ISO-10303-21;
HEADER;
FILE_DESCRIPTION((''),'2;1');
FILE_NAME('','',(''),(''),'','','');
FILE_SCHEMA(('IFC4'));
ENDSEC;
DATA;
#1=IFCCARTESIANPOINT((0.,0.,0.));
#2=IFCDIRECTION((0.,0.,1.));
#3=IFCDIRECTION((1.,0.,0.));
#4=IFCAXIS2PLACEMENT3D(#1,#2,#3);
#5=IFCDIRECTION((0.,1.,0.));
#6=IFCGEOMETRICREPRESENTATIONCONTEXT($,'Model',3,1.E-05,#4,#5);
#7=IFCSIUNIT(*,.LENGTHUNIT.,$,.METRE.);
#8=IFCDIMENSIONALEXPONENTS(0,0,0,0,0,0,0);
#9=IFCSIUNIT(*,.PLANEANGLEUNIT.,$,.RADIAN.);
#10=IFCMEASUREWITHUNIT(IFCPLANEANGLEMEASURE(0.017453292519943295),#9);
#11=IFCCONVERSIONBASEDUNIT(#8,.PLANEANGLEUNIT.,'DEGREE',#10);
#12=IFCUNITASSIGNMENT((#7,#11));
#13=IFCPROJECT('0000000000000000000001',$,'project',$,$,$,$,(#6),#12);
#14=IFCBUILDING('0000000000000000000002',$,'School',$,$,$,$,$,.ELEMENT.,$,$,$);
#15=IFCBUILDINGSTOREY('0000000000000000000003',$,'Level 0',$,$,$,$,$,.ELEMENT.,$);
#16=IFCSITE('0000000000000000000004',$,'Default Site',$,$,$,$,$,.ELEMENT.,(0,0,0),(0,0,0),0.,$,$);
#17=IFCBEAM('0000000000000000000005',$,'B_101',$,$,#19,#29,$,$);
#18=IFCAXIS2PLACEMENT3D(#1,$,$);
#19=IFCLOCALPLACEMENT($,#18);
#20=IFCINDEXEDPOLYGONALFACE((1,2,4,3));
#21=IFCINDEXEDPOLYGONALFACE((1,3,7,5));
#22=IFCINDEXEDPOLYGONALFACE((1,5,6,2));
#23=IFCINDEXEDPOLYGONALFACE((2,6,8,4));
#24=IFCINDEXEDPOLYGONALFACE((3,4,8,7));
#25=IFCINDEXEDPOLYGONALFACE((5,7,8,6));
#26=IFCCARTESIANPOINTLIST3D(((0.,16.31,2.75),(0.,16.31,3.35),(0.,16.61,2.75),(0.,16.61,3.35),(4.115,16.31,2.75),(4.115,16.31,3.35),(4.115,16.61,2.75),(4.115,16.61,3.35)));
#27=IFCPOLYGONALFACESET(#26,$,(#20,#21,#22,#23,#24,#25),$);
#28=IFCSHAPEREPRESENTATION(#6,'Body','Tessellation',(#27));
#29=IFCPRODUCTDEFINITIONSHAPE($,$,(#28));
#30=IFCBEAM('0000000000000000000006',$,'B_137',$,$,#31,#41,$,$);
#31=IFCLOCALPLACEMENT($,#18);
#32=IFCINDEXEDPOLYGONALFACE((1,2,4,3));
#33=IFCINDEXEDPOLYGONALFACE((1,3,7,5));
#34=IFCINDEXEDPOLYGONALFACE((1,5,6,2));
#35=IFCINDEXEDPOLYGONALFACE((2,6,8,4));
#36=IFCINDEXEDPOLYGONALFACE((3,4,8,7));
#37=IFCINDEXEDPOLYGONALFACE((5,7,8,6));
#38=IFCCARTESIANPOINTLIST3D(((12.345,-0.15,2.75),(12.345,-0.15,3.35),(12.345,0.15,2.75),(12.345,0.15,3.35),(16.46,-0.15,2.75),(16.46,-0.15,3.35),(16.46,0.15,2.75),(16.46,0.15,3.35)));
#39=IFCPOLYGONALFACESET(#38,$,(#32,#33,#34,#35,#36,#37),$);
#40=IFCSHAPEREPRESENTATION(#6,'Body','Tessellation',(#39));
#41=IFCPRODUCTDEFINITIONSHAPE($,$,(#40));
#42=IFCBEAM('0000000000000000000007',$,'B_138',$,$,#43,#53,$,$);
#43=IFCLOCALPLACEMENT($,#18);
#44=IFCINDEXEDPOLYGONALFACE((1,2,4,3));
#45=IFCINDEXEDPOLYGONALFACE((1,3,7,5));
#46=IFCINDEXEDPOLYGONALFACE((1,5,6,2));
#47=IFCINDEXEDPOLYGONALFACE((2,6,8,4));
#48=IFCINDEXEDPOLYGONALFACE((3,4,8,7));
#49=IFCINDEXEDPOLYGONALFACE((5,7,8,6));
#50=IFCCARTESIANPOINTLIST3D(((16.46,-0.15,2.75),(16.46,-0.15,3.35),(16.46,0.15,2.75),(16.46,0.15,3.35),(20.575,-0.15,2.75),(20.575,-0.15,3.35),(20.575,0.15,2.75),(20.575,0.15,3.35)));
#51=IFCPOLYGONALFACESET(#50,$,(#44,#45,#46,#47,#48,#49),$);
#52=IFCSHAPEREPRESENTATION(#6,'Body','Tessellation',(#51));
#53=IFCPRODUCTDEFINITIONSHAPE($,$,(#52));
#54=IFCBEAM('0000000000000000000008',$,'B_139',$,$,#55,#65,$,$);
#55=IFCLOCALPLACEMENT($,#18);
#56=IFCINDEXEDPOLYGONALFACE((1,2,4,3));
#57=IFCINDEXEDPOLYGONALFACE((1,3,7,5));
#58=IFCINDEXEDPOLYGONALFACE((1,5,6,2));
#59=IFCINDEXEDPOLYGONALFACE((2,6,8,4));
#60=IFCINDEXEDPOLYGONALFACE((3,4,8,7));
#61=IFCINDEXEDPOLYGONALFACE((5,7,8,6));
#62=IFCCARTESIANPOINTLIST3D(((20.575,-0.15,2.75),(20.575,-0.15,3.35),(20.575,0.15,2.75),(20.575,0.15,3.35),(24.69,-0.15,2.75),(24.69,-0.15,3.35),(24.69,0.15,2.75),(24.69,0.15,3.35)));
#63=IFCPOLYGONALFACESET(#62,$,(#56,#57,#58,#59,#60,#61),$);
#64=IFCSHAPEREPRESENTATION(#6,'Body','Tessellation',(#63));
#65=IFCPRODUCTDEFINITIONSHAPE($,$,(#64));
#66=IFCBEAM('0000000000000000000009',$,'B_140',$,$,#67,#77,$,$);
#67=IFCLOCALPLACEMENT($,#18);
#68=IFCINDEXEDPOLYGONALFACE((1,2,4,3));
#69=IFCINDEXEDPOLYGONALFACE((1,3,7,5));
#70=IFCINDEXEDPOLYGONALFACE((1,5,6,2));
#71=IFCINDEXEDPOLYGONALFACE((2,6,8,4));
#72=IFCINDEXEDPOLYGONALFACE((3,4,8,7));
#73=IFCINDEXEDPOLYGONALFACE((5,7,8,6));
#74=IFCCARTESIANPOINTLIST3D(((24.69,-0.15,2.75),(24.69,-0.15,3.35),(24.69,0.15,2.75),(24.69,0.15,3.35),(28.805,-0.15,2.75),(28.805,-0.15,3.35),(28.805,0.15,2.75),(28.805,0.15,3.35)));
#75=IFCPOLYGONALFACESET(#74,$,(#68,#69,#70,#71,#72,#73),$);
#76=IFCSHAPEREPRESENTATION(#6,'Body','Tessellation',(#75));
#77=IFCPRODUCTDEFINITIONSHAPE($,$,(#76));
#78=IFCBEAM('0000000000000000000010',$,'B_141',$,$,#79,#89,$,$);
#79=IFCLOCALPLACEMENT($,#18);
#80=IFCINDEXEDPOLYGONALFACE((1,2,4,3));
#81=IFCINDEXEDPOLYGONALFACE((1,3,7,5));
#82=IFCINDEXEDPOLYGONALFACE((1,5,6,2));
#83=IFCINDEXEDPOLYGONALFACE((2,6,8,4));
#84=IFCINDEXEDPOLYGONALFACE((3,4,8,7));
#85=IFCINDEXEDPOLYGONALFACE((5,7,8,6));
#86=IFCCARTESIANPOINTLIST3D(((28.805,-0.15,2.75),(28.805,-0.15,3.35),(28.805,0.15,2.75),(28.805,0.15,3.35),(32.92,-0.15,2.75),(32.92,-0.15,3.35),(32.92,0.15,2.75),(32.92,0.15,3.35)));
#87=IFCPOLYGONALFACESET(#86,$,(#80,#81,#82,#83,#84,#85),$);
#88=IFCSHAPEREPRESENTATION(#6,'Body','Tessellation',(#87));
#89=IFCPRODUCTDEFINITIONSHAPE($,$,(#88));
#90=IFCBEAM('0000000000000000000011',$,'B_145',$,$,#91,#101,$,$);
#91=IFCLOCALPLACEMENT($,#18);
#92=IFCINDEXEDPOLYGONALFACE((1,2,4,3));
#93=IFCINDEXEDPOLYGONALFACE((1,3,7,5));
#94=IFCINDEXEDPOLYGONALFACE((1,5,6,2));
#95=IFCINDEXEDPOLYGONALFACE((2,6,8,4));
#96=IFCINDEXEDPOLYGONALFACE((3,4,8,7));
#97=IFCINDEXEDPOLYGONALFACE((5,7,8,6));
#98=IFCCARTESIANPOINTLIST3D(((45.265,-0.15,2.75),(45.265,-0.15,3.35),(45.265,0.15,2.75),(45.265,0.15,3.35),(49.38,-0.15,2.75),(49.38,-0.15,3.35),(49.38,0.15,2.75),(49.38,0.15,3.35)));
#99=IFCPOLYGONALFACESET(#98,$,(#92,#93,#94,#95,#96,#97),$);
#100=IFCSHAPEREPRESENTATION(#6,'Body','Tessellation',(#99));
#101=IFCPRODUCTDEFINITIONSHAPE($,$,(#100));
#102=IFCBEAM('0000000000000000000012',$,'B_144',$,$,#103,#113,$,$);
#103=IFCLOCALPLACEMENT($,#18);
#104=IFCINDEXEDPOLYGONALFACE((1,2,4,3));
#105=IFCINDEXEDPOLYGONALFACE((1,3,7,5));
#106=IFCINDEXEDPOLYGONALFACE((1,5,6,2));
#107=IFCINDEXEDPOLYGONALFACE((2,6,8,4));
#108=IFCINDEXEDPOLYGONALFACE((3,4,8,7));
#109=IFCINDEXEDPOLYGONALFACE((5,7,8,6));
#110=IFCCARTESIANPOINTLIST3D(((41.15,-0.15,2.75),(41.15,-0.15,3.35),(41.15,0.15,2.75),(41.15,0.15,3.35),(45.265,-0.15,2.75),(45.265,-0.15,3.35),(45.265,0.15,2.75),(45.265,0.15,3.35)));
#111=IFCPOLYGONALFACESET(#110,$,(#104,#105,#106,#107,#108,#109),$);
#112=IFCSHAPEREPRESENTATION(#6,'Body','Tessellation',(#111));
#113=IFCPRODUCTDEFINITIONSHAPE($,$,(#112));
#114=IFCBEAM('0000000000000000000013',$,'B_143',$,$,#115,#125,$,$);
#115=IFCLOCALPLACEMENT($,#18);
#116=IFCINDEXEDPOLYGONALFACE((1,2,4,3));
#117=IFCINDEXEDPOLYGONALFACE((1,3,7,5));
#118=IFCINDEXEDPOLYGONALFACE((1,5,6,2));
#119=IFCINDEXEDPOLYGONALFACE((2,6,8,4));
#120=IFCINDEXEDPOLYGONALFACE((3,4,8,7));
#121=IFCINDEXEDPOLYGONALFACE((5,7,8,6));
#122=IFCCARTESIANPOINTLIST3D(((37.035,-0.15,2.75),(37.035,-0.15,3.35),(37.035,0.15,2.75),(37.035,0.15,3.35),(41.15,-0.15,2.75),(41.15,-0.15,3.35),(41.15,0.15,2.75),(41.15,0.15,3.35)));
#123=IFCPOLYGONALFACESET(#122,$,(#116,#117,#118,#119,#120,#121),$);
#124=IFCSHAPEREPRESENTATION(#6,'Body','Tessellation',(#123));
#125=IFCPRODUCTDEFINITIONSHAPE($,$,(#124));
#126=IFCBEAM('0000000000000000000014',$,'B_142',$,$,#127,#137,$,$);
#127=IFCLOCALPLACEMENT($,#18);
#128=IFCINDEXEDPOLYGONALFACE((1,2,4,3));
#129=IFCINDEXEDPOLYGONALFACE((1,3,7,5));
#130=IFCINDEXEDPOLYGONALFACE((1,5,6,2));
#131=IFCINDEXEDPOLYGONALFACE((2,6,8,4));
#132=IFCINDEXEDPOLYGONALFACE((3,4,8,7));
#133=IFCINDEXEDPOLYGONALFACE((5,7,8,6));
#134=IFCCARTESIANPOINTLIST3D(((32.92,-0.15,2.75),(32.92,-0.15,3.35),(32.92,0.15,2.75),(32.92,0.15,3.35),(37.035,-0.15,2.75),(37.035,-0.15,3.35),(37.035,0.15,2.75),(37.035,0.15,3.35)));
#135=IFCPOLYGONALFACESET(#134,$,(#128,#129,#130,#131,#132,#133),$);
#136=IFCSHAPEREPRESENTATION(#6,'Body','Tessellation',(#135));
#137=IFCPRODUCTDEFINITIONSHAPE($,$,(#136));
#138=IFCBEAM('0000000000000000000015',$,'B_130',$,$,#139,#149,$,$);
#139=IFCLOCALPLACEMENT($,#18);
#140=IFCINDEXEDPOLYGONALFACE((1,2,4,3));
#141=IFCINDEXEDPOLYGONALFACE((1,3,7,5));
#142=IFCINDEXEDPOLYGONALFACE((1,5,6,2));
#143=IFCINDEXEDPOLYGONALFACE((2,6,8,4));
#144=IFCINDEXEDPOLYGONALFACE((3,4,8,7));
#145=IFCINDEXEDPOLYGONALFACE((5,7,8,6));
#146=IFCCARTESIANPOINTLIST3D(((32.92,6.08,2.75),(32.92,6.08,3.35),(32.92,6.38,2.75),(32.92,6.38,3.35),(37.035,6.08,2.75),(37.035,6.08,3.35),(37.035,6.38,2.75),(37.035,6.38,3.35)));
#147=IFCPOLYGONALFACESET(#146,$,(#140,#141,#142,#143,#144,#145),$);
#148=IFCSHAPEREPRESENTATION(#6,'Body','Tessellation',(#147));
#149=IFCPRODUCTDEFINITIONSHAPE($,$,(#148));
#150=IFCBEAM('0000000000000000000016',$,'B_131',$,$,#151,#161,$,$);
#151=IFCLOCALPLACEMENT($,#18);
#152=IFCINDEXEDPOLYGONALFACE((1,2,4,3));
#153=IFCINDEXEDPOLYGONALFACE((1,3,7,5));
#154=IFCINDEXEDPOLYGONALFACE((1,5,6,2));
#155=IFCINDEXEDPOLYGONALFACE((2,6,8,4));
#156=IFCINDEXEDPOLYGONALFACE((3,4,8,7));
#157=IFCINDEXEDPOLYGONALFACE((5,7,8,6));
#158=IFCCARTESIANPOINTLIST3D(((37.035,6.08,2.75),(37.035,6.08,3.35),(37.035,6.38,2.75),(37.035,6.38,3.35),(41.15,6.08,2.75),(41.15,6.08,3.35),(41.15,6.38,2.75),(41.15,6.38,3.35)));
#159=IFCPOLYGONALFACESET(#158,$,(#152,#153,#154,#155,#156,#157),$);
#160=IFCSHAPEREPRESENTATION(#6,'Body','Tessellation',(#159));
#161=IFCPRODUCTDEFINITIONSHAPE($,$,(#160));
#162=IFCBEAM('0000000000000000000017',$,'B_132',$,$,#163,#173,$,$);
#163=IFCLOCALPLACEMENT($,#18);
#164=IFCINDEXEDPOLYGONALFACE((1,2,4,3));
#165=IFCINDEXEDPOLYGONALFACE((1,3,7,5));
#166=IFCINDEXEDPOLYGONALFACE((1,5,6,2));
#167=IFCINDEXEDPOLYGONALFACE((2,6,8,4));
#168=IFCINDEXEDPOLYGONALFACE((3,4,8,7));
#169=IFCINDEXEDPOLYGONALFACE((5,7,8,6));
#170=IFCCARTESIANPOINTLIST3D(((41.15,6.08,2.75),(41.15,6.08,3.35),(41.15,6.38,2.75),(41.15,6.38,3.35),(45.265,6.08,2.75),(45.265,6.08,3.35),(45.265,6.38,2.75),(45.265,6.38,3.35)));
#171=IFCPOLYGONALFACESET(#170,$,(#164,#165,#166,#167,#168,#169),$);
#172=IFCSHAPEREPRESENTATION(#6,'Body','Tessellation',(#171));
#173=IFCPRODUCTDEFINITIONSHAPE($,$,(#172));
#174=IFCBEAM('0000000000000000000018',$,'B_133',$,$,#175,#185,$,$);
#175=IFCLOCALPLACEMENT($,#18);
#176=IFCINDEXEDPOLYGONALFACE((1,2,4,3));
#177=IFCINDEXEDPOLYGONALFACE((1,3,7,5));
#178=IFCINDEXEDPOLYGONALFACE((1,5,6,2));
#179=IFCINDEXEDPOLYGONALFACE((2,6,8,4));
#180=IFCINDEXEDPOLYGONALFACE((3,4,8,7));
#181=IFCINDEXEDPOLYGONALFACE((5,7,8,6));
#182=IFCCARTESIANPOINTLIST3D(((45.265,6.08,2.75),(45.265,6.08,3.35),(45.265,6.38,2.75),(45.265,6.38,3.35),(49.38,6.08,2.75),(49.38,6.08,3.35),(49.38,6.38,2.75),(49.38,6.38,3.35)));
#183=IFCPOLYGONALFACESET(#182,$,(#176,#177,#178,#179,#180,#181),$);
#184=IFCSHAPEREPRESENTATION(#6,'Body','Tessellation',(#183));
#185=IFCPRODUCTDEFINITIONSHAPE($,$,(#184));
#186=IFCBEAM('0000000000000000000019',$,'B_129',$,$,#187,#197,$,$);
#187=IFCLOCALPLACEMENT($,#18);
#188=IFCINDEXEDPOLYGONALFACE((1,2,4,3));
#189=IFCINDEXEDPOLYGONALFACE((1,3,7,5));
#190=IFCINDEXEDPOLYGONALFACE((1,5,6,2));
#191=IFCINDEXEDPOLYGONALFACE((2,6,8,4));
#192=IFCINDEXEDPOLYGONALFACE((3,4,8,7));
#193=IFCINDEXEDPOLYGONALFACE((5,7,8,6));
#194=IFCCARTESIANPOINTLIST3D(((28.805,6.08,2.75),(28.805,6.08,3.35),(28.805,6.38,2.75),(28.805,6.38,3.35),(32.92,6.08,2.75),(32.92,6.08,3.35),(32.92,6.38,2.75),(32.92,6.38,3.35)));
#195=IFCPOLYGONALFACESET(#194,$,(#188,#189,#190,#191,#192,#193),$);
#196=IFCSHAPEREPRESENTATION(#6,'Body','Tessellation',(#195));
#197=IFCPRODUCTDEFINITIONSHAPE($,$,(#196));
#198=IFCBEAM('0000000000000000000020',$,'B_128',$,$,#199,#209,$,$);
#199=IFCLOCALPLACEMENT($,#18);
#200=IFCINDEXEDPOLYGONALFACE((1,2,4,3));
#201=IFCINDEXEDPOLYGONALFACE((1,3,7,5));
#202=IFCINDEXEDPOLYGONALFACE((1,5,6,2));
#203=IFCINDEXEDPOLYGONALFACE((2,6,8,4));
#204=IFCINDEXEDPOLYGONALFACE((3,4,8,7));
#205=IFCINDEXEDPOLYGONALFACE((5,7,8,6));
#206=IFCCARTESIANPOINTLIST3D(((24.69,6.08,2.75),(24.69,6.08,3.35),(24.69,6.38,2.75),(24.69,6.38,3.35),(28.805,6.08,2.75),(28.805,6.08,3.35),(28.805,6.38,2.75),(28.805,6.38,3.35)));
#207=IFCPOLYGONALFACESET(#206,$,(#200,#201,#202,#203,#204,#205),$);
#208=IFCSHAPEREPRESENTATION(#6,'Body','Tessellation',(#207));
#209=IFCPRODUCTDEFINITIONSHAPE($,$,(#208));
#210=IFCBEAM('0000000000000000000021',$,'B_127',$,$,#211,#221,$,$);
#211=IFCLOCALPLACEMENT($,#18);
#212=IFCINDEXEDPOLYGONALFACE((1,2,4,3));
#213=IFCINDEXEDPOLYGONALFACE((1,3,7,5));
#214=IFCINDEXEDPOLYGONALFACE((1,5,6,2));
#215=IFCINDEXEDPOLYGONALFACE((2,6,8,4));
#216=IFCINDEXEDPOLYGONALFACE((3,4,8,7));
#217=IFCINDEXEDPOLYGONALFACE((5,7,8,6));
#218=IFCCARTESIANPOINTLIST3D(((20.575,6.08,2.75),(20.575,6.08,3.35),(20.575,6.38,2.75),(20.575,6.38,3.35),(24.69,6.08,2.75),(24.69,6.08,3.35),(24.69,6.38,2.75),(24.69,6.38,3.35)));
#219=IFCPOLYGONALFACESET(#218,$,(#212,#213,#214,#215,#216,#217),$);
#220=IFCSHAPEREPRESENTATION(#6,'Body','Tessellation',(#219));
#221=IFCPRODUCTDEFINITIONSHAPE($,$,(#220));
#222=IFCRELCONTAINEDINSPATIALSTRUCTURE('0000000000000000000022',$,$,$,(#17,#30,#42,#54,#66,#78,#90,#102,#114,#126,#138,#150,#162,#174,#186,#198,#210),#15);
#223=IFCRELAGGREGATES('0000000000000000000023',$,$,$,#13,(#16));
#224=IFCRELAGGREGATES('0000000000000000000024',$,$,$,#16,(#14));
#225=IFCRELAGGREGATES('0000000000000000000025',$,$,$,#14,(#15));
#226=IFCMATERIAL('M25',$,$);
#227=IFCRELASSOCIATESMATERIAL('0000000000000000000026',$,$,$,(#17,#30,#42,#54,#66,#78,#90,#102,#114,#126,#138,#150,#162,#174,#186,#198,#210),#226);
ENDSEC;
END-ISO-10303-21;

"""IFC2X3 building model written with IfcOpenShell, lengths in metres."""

from ifc_helpers import new_model, entity, si_unit, converted_unit, direction, frame, frame_2d, origin_with_axes, place, context, project, spatial, rectangle, extrude, material, element, save


model = new_model("IFC2X3")

# Units and contexts
model_context = context("Model", 3, precision=1e-05, world=origin_with_axes(), true_north=direction((0.0, 1.0, 0.0)))
ifc_project = project(units=[si_unit("LENGTHUNIT", "METRE"), converted_unit("PLANEANGLEUNIT", "DEGREE", entity("IfcPlaneAngleMeasure", 0.017453292519943295), si_unit("PLANEANGLEUNIT", "RADIAN"), dimensions=[0, 0, 0, 0, 0, 0, 0])], contexts=[model_context])

# Site, building, storey
site = spatial("IfcSite", under=ifc_project, Name="Default Site", CompositionType="ELEMENT", RefLatitude=(0, 0, 0), RefLongitude=(0, 0, 0), RefElevation=0.0)
building = spatial("IfcBuilding", under=site, Name="School", CompositionType="ELEMENT")
storey = spatial("IfcBuildingStorey", under=building, Name="Level 0", CompositionType="ELEMENT")

# Beams
ifc_material = material(Name="M25")
placement = place(None, origin_with_axes())
element("IfcBeam", 1, at=placement, inside=storey, material=ifc_material, Name="B_101", context=model_context, shape_type="SweptSolid", body=[
    extrude(rectangle(XDim=0.3, YDim=0.6, at=frame_2d((0.0, 0.0), x_axis=(0.0, 1.0, 0.0))), frame((0.0, 16.46, 3.05), z_axis=(1.0, 0.0, 0.0), x_axis=(0.0, 0.0, -1.0)), (0.0, 0.0, 1.0), 4.115),
])
element("IfcBeam", 2, at=placement, inside=storey, material=ifc_material, Name="B_137", context=model_context, shape_type="SweptSolid", body=[
    extrude(rectangle(XDim=0.3, YDim=0.6, at=frame_2d((0.0, 0.0), x_axis=(0.0, 1.0, 0.0))), frame((12.345, 0.0, 3.05), z_axis=(1.0, 0.0, 0.0), x_axis=(0.0, 0.0, -1.0)), (0.0, 0.0, 1.0), 4.115),
])
element("IfcBeam", 3, at=placement, inside=storey, material=ifc_material, Name="B_138", context=model_context, shape_type="SweptSolid", body=[
    extrude(rectangle(XDim=0.3, YDim=0.6, at=frame_2d((0.0, 0.0), x_axis=(0.0, 1.0, 0.0))), frame((16.46, 0.0, 3.05), z_axis=(1.0, 0.0, 0.0), x_axis=(0.0, 0.0, -1.0)), (0.0, 0.0, 1.0), 4.115),
])
element("IfcBeam", 4, at=placement, inside=storey, material=ifc_material, Name="B_139", context=model_context, shape_type="SweptSolid", body=[
    extrude(rectangle(XDim=0.3, YDim=0.6, at=frame_2d((0.0, 0.0), x_axis=(0.0, 1.0, 0.0))), frame((20.575, 0.0, 3.05), z_axis=(1.0, 0.0, 0.0), x_axis=(0.0, 0.0, -1.0)), (0.0, 0.0, 1.0), 4.115),
])
element("IfcBeam", 5, at=placement, inside=storey, material=ifc_material, Name="B_140", context=model_context, shape_type="SweptSolid", body=[
    extrude(rectangle(XDim=0.3, YDim=0.6, at=frame_2d((0.0, 0.0), x_axis=(0.0, 1.0, 0.0))), frame((24.69, 0.0, 3.05), z_axis=(1.0, 0.0, 0.0), x_axis=(0.0, 0.0, -1.0)), (0.0, 0.0, 1.0), 4.115),
])
element("IfcBeam", 6, at=placement, inside=storey, material=ifc_material, Name="B_141", context=model_context, shape_type="SweptSolid", body=[
    extrude(rectangle(XDim=0.3, YDim=0.6, at=frame_2d((0.0, 0.0), x_axis=(0.0, 1.0, 0.0))), frame((28.805, 0.0, 3.05), z_axis=(1.0, 0.0, 0.0), x_axis=(0.0, 0.0, -1.0)), (0.0, 0.0, 1.0), 4.115),
])
element("IfcBeam", 7, at=placement, inside=storey, material=ifc_material, Name="B_145", context=model_context, shape_type="SweptSolid", body=[
    extrude(rectangle(XDim=0.3, YDim=0.6, at=frame_2d((0.0, 0.0), x_axis=(0.0, 1.0, 0.0))), frame((45.265, 0.0, 3.05), z_axis=(1.0, 0.0, 0.0), x_axis=(0.0, 0.0, -1.0)), (0.0, 0.0, 1.0), 4.115),
])
element("IfcBeam", 8, at=placement, inside=storey, material=ifc_material, Name="B_144", context=model_context, shape_type="SweptSolid", body=[
    extrude(rectangle(XDim=0.3, YDim=0.6, at=frame_2d((0.0, 0.0), x_axis=(0.0, 1.0, 0.0))), frame((41.15, 0.0, 3.05), z_axis=(1.0, 0.0, 0.0), x_axis=(0.0, 0.0, -1.0)), (0.0, 0.0, 1.0), 4.115),
])
element("IfcBeam", 9, at=placement, inside=storey, material=ifc_material, Name="B_143", context=model_context, shape_type="SweptSolid", body=[
    extrude(rectangle(XDim=0.3, YDim=0.6, at=frame_2d((0.0, 0.0), x_axis=(0.0, 1.0, 0.0))), frame((37.035, 0.0, 3.05), z_axis=(1.0, 0.0, 0.0), x_axis=(0.0, 0.0, -1.0)), (0.0, 0.0, 1.0), 4.115),
])
element("IfcBeam", 10, at=placement, inside=storey, material=ifc_material, Name="B_142", context=model_context, shape_type="SweptSolid", body=[
    extrude(rectangle(XDim=0.3, YDim=0.6, at=frame_2d((0.0, 0.0), x_axis=(0.0, 1.0, 0.0))), frame((32.92, 0.0, 3.05), z_axis=(1.0, 0.0, 0.0), x_axis=(0.0, 0.0, -1.0)), (0.0, 0.0, 1.0), 4.115),
])
element("IfcBeam", 11, at=placement, inside=storey, material=ifc_material, Name="B_130", context=model_context, shape_type="SweptSolid", body=[
    extrude(rectangle(XDim=0.3, YDim=0.6, at=frame_2d((0.0, 0.0), x_axis=(0.0, 1.0, 0.0))), frame((32.92, 6.23, 3.05), z_axis=(1.0, 0.0, 0.0), x_axis=(0.0, 0.0, -1.0)), (0.0, 0.0, 1.0), 4.115),
])
element("IfcBeam", 12, at=placement, inside=storey, material=ifc_material, Name="B_131", context=model_context, shape_type="SweptSolid", body=[
    extrude(rectangle(XDim=0.3, YDim=0.6, at=frame_2d((0.0, 0.0), x_axis=(0.0, 1.0, 0.0))), frame((37.035, 6.23, 3.05), z_axis=(1.0, 0.0, 0.0), x_axis=(0.0, 0.0, -1.0)), (0.0, 0.0, 1.0), 4.115),
])
element("IfcBeam", 13, at=placement, inside=storey, material=ifc_material, Name="B_132", context=model_context, shape_type="SweptSolid", body=[
    extrude(rectangle(XDim=0.3, YDim=0.6, at=frame_2d((0.0, 0.0), x_axis=(0.0, 1.0, 0.0))), frame((41.15, 6.23, 3.05), z_axis=(1.0, 0.0, 0.0), x_axis=(0.0, 0.0, -1.0)), (0.0, 0.0, 1.0), 4.115),
])
element("IfcBeam", 14, at=placement, inside=storey, material=ifc_material, Name="B_133", context=model_context, shape_type="SweptSolid", body=[
    extrude(rectangle(XDim=0.3, YDim=0.6, at=frame_2d((0.0, 0.0), x_axis=(0.0, 1.0, 0.0))), frame((45.265, 6.23, 3.05), z_axis=(1.0, 0.0, 0.0), x_axis=(0.0, 0.0, -1.0)), (0.0, 0.0, 1.0), 4.115),
])
element("IfcBeam", 15, at=placement, inside=storey, material=ifc_material, Name="B_129", context=model_context, shape_type="SweptSolid", body=[
    extrude(rectangle(XDim=0.3, YDim=0.6, at=frame_2d((0.0, 0.0), x_axis=(0.0, 1.0, 0.0))), frame((28.805, 6.23, 3.05), z_axis=(1.0, 0.0, 0.0), x_axis=(0.0, 0.0, -1.0)), (0.0, 0.0, 1.0), 4.115),
])
element("IfcBeam", 16, at=placement, inside=storey, material=ifc_material, Name="B_128", context=model_context, shape_type="SweptSolid", body=[
    extrude(rectangle(XDim=0.3, YDim=0.6, at=frame_2d((0.0, 0.0), x_axis=(0.0, 1.0, 0.0))), frame((24.69, 6.23, 3.05), z_axis=(1.0, 0.0, 0.0), x_axis=(0.0, 0.0, -1.0)), (0.0, 0.0, 1.0), 4.115),
])
element("IfcBeam", 17, at=placement, inside=storey, material=ifc_material, Name="B_127", context=model_context, shape_type="SweptSolid", body=[
    extrude(rectangle(XDim=0.3, YDim=0.6, at=frame_2d((0.0, 0.0), x_axis=(0.0, 1.0, 0.0))), frame((20.575, 6.23, 3.05), z_axis=(1.0, 0.0, 0.0), x_axis=(0.0, 0.0, -1.0)), (0.0, 0.0, 1.0), 4.115),
])

save(model, "model.ifc")
